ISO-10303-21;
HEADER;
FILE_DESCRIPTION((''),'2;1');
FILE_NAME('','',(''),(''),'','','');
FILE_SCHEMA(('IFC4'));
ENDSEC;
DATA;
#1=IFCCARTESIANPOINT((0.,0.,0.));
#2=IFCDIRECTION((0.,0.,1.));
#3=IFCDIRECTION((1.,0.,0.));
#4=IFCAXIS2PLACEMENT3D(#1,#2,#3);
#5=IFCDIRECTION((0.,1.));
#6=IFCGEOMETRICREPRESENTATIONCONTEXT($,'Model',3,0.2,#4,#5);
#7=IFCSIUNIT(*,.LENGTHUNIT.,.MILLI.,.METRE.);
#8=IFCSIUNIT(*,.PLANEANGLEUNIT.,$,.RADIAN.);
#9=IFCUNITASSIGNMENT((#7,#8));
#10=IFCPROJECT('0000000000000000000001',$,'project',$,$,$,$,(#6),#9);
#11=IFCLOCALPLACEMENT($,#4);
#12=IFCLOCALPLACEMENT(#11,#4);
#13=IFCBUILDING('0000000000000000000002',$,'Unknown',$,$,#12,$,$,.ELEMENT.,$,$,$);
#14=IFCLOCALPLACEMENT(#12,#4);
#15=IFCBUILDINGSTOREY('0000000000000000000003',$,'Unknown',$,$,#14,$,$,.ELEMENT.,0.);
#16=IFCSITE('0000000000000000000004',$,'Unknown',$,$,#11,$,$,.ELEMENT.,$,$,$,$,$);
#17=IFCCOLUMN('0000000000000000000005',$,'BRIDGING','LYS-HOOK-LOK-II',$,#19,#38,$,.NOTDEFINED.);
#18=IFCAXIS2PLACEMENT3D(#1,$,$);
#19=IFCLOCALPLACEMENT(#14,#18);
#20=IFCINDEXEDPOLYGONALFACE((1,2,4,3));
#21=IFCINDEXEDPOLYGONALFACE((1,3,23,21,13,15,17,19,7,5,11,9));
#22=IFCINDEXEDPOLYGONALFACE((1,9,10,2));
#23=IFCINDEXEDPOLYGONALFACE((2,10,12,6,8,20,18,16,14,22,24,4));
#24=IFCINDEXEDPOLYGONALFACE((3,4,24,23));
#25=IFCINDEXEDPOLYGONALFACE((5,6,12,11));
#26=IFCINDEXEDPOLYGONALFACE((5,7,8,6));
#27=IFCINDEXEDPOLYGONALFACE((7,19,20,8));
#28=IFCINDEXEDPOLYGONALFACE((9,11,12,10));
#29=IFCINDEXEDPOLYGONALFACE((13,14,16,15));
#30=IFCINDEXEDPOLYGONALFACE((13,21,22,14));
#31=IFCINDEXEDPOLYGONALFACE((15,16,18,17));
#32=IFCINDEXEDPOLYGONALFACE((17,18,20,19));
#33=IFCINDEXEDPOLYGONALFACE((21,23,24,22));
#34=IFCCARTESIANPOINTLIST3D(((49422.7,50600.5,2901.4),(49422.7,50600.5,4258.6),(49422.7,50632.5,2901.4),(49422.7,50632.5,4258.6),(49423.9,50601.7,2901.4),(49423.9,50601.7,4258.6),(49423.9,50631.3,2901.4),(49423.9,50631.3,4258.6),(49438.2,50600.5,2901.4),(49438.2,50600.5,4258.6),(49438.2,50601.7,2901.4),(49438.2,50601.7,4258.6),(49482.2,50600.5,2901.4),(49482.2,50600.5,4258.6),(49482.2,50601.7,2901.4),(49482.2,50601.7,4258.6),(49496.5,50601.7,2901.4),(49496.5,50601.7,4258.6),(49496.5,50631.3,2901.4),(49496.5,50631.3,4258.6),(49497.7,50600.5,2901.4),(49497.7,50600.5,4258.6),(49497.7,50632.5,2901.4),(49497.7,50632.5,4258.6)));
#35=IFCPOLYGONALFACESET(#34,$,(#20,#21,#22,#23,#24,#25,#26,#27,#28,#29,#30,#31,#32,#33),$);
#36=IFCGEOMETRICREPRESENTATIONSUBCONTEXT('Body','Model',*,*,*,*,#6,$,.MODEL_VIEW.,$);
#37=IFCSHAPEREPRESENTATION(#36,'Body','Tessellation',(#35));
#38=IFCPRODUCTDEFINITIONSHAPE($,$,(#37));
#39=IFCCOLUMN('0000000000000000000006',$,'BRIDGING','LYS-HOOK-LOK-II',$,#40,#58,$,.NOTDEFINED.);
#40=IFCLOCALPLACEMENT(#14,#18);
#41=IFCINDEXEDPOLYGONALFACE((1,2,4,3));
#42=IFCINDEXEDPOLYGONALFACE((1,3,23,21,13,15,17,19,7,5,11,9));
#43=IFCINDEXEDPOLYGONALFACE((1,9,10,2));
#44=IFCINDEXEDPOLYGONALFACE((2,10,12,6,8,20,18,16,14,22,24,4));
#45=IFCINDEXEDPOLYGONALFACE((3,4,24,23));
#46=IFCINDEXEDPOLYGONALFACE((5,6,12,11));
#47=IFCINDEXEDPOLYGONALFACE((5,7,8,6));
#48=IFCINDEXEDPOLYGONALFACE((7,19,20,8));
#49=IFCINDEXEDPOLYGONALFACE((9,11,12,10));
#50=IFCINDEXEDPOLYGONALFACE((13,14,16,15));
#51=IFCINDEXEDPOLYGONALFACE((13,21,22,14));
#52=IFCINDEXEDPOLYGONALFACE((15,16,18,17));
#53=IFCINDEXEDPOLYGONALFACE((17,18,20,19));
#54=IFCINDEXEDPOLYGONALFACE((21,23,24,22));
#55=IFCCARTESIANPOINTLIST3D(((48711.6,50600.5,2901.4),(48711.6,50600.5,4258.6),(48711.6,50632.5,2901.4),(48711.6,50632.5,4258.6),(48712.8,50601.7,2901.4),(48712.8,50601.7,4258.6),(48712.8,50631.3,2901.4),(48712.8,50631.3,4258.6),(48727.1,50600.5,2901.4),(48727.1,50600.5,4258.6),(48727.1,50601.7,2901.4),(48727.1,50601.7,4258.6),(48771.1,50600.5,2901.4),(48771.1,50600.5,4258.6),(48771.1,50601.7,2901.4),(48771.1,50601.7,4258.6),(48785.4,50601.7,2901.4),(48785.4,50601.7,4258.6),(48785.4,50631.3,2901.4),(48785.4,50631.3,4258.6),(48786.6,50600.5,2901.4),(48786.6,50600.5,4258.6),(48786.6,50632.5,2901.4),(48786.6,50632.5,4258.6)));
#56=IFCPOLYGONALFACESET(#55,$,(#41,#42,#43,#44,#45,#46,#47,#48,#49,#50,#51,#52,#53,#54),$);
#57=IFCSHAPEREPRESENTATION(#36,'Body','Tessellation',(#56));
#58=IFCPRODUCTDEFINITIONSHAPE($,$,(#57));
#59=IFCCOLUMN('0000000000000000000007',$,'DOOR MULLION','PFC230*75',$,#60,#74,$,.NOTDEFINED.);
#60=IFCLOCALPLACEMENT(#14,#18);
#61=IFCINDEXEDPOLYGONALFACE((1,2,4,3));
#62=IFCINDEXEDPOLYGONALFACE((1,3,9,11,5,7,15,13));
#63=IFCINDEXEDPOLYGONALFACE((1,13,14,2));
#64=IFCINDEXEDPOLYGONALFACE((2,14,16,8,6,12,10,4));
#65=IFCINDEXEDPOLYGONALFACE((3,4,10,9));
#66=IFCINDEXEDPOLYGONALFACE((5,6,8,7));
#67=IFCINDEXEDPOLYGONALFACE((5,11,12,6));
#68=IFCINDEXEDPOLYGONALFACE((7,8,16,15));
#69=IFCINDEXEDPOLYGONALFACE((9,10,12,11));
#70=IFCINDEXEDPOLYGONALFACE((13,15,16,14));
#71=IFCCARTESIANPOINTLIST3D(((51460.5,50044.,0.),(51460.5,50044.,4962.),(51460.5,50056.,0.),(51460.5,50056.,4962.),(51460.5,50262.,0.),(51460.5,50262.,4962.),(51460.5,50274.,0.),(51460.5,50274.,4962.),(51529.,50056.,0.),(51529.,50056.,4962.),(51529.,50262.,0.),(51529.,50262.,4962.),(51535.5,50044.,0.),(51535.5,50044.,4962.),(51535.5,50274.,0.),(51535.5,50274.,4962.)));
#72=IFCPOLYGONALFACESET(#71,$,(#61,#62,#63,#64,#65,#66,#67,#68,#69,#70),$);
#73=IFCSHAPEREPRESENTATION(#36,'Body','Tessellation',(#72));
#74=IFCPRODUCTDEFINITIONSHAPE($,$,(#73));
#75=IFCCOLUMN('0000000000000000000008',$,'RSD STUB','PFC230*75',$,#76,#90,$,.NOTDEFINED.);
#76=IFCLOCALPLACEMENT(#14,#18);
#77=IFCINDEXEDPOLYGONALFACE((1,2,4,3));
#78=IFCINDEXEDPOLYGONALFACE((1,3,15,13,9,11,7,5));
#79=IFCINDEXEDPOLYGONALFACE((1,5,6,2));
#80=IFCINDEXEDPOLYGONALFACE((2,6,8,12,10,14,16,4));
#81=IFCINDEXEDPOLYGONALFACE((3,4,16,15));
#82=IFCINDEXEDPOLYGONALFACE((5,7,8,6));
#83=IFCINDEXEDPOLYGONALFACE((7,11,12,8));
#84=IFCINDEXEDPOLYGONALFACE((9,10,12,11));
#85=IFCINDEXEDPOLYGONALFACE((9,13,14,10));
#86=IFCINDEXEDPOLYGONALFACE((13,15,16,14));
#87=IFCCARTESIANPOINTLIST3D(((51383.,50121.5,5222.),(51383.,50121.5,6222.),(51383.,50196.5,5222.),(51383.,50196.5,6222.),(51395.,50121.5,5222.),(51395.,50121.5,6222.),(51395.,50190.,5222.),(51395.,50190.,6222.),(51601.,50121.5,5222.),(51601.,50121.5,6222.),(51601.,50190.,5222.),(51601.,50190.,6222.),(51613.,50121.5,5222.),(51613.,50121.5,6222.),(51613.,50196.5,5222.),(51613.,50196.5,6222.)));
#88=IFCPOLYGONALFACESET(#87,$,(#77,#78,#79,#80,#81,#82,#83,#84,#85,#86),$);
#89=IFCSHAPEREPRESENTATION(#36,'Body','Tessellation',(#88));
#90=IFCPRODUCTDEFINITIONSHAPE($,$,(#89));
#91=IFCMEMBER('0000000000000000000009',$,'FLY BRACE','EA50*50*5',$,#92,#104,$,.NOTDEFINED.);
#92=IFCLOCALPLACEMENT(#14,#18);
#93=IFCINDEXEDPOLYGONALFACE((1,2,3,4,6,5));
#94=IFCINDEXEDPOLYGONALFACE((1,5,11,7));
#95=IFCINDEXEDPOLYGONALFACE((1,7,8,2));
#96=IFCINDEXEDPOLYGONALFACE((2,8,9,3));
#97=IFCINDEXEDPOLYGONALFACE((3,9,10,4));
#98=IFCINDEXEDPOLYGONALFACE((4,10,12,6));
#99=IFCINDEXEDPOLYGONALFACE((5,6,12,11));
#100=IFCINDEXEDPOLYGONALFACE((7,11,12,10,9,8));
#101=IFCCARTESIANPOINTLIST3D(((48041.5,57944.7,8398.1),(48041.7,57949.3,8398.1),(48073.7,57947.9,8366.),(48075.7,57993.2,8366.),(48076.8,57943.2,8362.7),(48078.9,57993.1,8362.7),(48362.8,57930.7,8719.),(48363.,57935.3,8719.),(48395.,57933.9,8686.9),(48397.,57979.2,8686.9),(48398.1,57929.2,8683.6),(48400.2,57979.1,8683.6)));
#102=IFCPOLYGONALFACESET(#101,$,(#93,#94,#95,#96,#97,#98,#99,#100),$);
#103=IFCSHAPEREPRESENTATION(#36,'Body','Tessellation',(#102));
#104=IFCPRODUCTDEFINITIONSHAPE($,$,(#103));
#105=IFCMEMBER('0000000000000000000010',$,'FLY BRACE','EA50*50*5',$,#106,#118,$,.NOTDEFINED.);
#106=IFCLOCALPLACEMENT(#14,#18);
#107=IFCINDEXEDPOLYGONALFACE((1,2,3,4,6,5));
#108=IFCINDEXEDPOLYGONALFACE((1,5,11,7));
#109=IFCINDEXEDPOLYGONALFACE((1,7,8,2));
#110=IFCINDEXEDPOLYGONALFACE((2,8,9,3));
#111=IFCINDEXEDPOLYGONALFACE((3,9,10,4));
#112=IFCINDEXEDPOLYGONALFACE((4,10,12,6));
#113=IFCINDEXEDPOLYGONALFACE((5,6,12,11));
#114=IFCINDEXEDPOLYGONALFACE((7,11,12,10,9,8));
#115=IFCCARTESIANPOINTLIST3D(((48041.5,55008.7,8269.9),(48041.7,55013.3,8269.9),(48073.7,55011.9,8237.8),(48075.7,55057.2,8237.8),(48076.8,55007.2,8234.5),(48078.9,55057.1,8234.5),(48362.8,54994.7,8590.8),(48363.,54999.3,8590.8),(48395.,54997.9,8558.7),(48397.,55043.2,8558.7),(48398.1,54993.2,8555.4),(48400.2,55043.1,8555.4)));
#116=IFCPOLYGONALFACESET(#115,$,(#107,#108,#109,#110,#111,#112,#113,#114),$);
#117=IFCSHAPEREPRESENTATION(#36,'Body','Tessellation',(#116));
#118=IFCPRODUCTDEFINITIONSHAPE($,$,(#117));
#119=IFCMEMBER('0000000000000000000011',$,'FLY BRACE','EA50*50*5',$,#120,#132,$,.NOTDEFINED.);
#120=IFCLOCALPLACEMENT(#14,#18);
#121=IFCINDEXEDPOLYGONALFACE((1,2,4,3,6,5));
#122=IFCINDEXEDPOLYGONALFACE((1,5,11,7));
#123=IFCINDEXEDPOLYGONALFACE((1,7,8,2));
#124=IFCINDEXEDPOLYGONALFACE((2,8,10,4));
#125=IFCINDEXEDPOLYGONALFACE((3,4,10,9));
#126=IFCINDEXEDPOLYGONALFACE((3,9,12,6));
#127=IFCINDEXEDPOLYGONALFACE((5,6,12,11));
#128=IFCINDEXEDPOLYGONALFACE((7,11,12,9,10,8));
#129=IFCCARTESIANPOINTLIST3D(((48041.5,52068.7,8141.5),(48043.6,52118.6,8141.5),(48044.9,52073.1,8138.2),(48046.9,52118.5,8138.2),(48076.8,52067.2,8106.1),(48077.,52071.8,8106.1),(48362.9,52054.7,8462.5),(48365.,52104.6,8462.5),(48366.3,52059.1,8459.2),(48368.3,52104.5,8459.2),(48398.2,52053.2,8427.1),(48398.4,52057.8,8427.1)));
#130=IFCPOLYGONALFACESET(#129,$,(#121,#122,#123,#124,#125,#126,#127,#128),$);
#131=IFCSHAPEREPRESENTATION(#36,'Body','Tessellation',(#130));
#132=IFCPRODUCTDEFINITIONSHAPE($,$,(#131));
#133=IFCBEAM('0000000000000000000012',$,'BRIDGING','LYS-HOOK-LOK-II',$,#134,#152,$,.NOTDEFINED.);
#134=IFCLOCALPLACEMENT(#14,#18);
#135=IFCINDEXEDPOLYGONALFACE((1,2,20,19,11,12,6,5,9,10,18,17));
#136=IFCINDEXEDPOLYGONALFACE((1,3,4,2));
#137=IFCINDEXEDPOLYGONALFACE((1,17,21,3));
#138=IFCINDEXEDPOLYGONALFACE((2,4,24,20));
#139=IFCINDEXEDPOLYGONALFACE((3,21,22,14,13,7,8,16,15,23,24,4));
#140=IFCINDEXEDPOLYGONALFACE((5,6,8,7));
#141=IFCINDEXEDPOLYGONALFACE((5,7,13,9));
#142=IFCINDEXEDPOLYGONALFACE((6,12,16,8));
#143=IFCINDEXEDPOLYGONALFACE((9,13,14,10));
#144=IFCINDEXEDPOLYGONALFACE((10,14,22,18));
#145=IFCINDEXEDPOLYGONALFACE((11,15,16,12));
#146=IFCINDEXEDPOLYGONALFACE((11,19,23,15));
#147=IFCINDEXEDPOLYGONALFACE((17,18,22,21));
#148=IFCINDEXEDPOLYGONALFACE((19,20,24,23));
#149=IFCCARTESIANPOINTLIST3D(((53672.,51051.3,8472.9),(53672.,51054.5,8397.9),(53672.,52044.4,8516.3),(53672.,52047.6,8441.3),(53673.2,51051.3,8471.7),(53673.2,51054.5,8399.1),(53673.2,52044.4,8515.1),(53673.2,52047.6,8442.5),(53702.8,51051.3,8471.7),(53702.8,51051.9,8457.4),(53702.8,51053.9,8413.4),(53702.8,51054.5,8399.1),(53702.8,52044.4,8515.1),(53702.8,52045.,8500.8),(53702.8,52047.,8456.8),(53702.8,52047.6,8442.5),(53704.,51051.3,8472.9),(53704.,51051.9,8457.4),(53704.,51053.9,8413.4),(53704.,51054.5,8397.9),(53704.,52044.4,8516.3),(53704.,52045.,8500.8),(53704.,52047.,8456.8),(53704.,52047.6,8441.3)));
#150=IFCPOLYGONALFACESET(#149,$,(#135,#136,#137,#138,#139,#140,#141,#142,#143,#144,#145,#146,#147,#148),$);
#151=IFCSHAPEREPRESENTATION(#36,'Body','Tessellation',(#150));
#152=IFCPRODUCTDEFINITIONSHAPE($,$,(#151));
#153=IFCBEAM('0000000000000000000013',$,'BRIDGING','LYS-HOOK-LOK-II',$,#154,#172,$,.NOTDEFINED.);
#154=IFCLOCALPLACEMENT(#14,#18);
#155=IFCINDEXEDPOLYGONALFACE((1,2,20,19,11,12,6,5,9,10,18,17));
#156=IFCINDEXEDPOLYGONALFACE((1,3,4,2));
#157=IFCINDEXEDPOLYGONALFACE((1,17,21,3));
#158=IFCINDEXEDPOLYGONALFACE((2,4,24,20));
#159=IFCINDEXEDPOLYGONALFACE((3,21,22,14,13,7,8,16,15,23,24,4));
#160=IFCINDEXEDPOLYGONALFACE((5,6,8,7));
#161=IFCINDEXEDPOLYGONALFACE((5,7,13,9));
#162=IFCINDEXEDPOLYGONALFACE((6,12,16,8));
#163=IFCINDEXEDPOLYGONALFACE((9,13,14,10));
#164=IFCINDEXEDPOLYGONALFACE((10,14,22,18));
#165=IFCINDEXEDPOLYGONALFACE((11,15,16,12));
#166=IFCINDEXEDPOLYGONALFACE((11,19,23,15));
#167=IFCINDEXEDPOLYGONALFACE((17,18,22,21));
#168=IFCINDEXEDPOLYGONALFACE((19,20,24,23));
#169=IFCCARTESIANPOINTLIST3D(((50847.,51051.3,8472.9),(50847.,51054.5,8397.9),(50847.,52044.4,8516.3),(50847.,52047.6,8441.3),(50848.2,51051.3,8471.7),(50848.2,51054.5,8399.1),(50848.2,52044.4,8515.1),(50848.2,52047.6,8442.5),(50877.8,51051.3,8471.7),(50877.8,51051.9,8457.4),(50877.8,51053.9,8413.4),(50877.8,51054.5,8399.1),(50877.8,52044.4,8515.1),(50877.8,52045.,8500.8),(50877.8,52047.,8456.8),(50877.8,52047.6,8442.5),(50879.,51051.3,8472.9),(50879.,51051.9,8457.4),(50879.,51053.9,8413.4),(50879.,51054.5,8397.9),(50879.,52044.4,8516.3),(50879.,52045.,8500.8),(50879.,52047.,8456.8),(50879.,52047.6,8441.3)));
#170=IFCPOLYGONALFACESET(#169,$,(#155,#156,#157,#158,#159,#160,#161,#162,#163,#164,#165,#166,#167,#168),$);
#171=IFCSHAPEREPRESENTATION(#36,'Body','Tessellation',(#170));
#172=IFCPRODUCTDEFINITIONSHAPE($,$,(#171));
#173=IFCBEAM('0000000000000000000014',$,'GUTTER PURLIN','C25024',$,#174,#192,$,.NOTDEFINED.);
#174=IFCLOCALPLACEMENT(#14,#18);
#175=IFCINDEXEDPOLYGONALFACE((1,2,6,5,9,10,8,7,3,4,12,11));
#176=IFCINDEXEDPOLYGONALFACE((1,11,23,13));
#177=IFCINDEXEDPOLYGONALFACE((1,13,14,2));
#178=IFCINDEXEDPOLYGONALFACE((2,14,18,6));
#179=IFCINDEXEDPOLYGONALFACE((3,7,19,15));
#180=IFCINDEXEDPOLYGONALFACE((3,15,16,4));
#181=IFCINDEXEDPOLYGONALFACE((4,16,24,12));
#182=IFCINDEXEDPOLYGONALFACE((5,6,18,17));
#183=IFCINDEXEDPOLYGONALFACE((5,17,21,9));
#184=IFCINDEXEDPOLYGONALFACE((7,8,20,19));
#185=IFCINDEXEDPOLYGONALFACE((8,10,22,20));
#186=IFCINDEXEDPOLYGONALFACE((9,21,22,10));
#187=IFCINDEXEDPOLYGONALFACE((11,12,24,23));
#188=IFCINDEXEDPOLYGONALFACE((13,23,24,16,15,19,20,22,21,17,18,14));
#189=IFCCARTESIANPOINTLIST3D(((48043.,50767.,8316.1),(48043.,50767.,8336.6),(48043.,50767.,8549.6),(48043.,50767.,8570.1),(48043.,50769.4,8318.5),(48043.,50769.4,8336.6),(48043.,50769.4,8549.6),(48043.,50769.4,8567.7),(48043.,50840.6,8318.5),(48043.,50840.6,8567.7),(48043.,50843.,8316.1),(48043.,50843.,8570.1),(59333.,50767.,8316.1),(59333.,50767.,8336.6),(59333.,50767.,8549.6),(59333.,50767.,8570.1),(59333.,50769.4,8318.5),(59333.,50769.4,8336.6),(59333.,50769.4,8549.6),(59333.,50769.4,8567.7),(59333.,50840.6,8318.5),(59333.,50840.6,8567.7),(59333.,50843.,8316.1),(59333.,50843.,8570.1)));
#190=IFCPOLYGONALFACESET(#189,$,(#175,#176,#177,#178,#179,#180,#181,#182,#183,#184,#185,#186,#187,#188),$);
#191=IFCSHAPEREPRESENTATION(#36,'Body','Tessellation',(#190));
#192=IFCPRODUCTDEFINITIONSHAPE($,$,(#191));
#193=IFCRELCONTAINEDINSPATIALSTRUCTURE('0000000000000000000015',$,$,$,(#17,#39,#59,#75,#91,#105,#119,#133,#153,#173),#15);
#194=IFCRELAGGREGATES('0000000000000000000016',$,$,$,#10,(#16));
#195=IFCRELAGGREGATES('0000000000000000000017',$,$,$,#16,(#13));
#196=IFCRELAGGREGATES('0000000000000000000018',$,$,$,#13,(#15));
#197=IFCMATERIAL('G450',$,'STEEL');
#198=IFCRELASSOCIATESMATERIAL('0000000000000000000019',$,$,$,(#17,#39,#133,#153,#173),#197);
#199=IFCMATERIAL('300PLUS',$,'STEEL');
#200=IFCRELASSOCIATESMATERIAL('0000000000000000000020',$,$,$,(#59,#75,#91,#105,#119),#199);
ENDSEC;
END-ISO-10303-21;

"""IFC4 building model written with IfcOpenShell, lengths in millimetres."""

from ifc_helpers import new_model, si_unit, direction, frame, origin_with_axes, place, context, subcontext, project, spatial, line, indexed_curve, outline, extrude, material, element, save


model = new_model("IFC4")

# Units and contexts
model_context = context("Model", 3, precision=0.2, world=origin_with_axes(), true_north=direction((0.0, 1.0)))
body_context = subcontext(model_context, "Body", "Model", "MODEL_VIEW")
ifc_project = project(units=[si_unit("LENGTHUNIT", "METRE", prefix="MILLI"), si_unit("PLANEANGLEUNIT", "RADIAN")], contexts=[model_context])

# Site, building, storey
site_placement = place(None, origin_with_axes())
site = spatial("IfcSite", under=ifc_project, at=site_placement, Name="Unknown", CompositionType="ELEMENT")
building_placement = place(site_placement, origin_with_axes())
building = spatial("IfcBuilding", under=site, at=building_placement, Name="Unknown", CompositionType="ELEMENT")
storey_placement = place(building_placement, origin_with_axes())
storey = spatial("IfcBuildingStorey", under=building, at=storey_placement, Name="Unknown", CompositionType="ELEMENT", Elevation=0.0)

# Columns
ifc_material_1 = material(Name="G450", Category="STEEL")
for number, where, z_axis, x_axis, name in (
    (1, (49460.2, 50616.5, 2901.4), (0.0, -1.0, 0.0), (0.0, 0.0, 1.0), "BRIDGING"),
    (2, (48749.1, 50616.5, 2901.4), (0.0, -1.0, 0.0), (0.0, 0.0, 1.0), "BRIDGING"),
):
    element("IfcColumn", number, at=place(storey_placement, frame(where, z_axis=z_axis, x_axis=x_axis)), inside=storey, material=ifc_material_1, Name=name, Description="LYS-HOOK-LOK-II", PredefinedType="NOTDEFINED", context=body_context, shape_type="SolidModel", body=[
        extrude(outline(indexed_curve([(16.0, -37.5), (16.0, -22.0), (14.8, -22.0), (14.8, -36.3), (-14.8, -36.3), (-14.8, 36.3), (14.8, 36.3), (14.8, 22.0), (16.0, 22.0), (16.0, 37.5), (-16.0, 37.5), (-16.0, -37.5)], segments=[line(1, 2, 3, 4, 5, 6, 7, 8, 9, 10, 11, 12, 1)])), frame((0.0, 0.0, 0.0), z_axis=(-1.0, 0.0, 0.0), x_axis=(0.0, 0.0, 1.0)), (0.0, 0.0, -1.0), 1357.2),
    ])
ifc_material_2 = material(Name="300PLUS", Category="STEEL")
column_1_placement = place(storey_placement, frame((51498.0, 50159.0, 0.0), z_axis=(-1.0, 0.0, 0.0), x_axis=(0.0, 0.0, 1.0)))
element("IfcColumn", 3, at=column_1_placement, inside=storey, material=ifc_material_2, Name="DOOR MULLION", Description="PFC230*75", PredefinedType="NOTDEFINED", context=body_context, shape_type="SolidModel", body=[
    extrude(outline(indexed_curve([(-37.5, -115.0), (37.5, -115.0), (37.5, -103.0), (-31.0, -103.0), (-31.0, 103.0), (37.5, 103.0), (37.5, 115.0), (-37.5, 115.0)], segments=[line(1, 2, 3, 4, 5, 6, 7, 8, 1)])), frame((0.0, 0.0, 0.0), z_axis=(-1.0, 0.0, 0.0), x_axis=(0.0, 0.0, 1.0)), (0.0, 0.0, -1.0), 4962.0),
])
column_2_placement = place(storey_placement, frame((51498.0, 50159.0, 5222.0), z_axis=(0.0, -1.0, 0.0), x_axis=(0.0, 0.0, 1.0)))
element("IfcColumn", 4, at=column_2_placement, inside=storey, material=ifc_material_2, Name="RSD STUB", Description="PFC230*75", PredefinedType="NOTDEFINED", context=body_context, shape_type="SolidModel", body=[
    extrude(outline(indexed_curve([(-37.5, -115.0), (37.5, -115.0), (37.5, -103.0), (-31.0, -103.0), (-31.0, 103.0), (37.5, 103.0), (37.5, 115.0), (-37.5, 115.0)], segments=[line(1, 2, 3, 4, 5, 6, 7, 8, 1)])), frame((0.0, 0.0, 0.0), z_axis=(-1.0, 0.0, 0.0), x_axis=(0.0, 0.0, 1.0)), (0.0, 0.0, -1.0), 1000.0),
])

# Members
for number, where, z_axis, x_axis, name in (
    (5, (48060.2, 57968.9, 8380.4), (-0.705661, 0.030748, 0.707882), (0.707211, -0.030815, 0.706331), "FLY BRACE"),
    (6, (48060.2, 55032.9, 8252.2), (-0.705661, 0.030748, 0.707882), (0.707211, -0.030815, 0.706331), "FLY BRACE"),
):
    element("IfcMember", number, at=place(storey_placement, frame(where, z_axis=z_axis, x_axis=x_axis)), inside=storey, material=ifc_material_2, Name=name, Description="EA50*50*5", PredefinedType="NOTDEFINED", context=body_context, shape_type="SolidModel", body=[
        extrude(outline(indexed_curve([(-25.0, -25.0), (25.0, -25.0), (25.0, -20.4), (-20.4, -20.4), (-20.4, 25.0), (-25.0, 25.0)], segments=[line(1, 2, 3, 4, 5, 6, 1)])), frame((0.0, 0.0, 0.0), z_axis=(-1.0, 0.0, 0.0), x_axis=(0.0, 0.0, 1.0)), (0.0, 0.0, -1.0), 454.3),
    ])
member_placement = place(storey_placement, frame((48060.2, 52092.9, 8123.8), z_axis=(0.043518, 0.999053, 0.0), x_axis=(0.707211, -0.030806, 0.706331)))
element("IfcMember", 7, at=member_placement, inside=storey, material=ifc_material_2, Name="FLY BRACE", Description="EA50*50*5", PredefinedType="NOTDEFINED", context=body_context, shape_type="SolidModel", body=[
    extrude(outline(indexed_curve([(-25.0, -25.0), (25.0, -25.0), (25.0, -20.4), (-20.4, -20.4), (-20.4, 25.0), (-25.0, 25.0)], segments=[line(1, 2, 3, 4, 5, 6, 1)])), frame((0.0, 0.0, 0.0), z_axis=(-1.0, 0.0, 0.0), x_axis=(0.0, 0.0, 1.0)), (0.0, 0.0, -1.0), 454.5),
])

# Beams
for number, where, z_axis, x_axis, name in (
    (8, (53688.0, 51052.9, 8435.4), (1.0, 0.0, 0.0), (0.0, 0.999046, 0.04366), "BRIDGING"),
    (9, (50863.0, 51052.9, 8435.4), (1.0, 0.0, 0.0), (0.0, 0.999046, 0.04366), "BRIDGING"),
):
    element("IfcBeam", number, at=place(storey_placement, frame(where, z_axis=z_axis, x_axis=x_axis)), inside=storey, material=ifc_material_1, Name=name, Description="LYS-HOOK-LOK-II", PredefinedType="NOTDEFINED", context=body_context, shape_type="SolidModel", body=[
        extrude(outline(indexed_curve([(16.0, -37.5), (16.0, -22.0), (14.8, -22.0), (14.8, -36.3), (-14.8, -36.3), (-14.8, 36.3), (14.8, 36.3), (14.8, 22.0), (16.0, 22.0), (16.0, 37.5), (-16.0, 37.5), (-16.0, -37.5)], segments=[line(1, 2, 3, 4, 5, 6, 7, 8, 9, 10, 11, 12, 1)])), frame((0.0, 0.0, 0.0), z_axis=(-1.0, 0.0, 0.0), x_axis=(0.0, 0.0, 1.0)), (0.0, 0.0, -1.0), 994.0),
    ])
beam_1_placement = place(storey_placement, frame((48043.0, 50805.0, 8443.1), z_axis=(0.0, -1.0, 0.0), x_axis=(1.0, 0.0, 0.0)))
element("IfcBeam", 10, at=beam_1_placement, inside=storey, material=ifc_material_1, Name="GUTTER PURLIN", Description="C25024", PredefinedType="NOTDEFINED", context=body_context, shape_type="SolidModel", body=[
    extrude(outline(indexed_curve([(38.0, -127.0), (38.0, -106.5), (35.6, -106.5), (35.6, -124.6), (-35.6, -124.6), (-35.6, 124.6), (35.6, 124.6), (35.6, 106.5), (38.0, 106.5), (38.0, 127.0), (-38.0, 127.0), (-38.0, -127.0)], segments=[line(1, 2, 3, 4, 5, 6, 7, 8, 9, 10, 11, 12, 1)])), frame((0.0, 0.0, 0.0), z_axis=(-1.0, 0.0, 0.0), x_axis=(0.0, 0.0, 1.0)), (0.0, 0.0, -1.0), 11290.0),
])

save(model, "model.ifc")
